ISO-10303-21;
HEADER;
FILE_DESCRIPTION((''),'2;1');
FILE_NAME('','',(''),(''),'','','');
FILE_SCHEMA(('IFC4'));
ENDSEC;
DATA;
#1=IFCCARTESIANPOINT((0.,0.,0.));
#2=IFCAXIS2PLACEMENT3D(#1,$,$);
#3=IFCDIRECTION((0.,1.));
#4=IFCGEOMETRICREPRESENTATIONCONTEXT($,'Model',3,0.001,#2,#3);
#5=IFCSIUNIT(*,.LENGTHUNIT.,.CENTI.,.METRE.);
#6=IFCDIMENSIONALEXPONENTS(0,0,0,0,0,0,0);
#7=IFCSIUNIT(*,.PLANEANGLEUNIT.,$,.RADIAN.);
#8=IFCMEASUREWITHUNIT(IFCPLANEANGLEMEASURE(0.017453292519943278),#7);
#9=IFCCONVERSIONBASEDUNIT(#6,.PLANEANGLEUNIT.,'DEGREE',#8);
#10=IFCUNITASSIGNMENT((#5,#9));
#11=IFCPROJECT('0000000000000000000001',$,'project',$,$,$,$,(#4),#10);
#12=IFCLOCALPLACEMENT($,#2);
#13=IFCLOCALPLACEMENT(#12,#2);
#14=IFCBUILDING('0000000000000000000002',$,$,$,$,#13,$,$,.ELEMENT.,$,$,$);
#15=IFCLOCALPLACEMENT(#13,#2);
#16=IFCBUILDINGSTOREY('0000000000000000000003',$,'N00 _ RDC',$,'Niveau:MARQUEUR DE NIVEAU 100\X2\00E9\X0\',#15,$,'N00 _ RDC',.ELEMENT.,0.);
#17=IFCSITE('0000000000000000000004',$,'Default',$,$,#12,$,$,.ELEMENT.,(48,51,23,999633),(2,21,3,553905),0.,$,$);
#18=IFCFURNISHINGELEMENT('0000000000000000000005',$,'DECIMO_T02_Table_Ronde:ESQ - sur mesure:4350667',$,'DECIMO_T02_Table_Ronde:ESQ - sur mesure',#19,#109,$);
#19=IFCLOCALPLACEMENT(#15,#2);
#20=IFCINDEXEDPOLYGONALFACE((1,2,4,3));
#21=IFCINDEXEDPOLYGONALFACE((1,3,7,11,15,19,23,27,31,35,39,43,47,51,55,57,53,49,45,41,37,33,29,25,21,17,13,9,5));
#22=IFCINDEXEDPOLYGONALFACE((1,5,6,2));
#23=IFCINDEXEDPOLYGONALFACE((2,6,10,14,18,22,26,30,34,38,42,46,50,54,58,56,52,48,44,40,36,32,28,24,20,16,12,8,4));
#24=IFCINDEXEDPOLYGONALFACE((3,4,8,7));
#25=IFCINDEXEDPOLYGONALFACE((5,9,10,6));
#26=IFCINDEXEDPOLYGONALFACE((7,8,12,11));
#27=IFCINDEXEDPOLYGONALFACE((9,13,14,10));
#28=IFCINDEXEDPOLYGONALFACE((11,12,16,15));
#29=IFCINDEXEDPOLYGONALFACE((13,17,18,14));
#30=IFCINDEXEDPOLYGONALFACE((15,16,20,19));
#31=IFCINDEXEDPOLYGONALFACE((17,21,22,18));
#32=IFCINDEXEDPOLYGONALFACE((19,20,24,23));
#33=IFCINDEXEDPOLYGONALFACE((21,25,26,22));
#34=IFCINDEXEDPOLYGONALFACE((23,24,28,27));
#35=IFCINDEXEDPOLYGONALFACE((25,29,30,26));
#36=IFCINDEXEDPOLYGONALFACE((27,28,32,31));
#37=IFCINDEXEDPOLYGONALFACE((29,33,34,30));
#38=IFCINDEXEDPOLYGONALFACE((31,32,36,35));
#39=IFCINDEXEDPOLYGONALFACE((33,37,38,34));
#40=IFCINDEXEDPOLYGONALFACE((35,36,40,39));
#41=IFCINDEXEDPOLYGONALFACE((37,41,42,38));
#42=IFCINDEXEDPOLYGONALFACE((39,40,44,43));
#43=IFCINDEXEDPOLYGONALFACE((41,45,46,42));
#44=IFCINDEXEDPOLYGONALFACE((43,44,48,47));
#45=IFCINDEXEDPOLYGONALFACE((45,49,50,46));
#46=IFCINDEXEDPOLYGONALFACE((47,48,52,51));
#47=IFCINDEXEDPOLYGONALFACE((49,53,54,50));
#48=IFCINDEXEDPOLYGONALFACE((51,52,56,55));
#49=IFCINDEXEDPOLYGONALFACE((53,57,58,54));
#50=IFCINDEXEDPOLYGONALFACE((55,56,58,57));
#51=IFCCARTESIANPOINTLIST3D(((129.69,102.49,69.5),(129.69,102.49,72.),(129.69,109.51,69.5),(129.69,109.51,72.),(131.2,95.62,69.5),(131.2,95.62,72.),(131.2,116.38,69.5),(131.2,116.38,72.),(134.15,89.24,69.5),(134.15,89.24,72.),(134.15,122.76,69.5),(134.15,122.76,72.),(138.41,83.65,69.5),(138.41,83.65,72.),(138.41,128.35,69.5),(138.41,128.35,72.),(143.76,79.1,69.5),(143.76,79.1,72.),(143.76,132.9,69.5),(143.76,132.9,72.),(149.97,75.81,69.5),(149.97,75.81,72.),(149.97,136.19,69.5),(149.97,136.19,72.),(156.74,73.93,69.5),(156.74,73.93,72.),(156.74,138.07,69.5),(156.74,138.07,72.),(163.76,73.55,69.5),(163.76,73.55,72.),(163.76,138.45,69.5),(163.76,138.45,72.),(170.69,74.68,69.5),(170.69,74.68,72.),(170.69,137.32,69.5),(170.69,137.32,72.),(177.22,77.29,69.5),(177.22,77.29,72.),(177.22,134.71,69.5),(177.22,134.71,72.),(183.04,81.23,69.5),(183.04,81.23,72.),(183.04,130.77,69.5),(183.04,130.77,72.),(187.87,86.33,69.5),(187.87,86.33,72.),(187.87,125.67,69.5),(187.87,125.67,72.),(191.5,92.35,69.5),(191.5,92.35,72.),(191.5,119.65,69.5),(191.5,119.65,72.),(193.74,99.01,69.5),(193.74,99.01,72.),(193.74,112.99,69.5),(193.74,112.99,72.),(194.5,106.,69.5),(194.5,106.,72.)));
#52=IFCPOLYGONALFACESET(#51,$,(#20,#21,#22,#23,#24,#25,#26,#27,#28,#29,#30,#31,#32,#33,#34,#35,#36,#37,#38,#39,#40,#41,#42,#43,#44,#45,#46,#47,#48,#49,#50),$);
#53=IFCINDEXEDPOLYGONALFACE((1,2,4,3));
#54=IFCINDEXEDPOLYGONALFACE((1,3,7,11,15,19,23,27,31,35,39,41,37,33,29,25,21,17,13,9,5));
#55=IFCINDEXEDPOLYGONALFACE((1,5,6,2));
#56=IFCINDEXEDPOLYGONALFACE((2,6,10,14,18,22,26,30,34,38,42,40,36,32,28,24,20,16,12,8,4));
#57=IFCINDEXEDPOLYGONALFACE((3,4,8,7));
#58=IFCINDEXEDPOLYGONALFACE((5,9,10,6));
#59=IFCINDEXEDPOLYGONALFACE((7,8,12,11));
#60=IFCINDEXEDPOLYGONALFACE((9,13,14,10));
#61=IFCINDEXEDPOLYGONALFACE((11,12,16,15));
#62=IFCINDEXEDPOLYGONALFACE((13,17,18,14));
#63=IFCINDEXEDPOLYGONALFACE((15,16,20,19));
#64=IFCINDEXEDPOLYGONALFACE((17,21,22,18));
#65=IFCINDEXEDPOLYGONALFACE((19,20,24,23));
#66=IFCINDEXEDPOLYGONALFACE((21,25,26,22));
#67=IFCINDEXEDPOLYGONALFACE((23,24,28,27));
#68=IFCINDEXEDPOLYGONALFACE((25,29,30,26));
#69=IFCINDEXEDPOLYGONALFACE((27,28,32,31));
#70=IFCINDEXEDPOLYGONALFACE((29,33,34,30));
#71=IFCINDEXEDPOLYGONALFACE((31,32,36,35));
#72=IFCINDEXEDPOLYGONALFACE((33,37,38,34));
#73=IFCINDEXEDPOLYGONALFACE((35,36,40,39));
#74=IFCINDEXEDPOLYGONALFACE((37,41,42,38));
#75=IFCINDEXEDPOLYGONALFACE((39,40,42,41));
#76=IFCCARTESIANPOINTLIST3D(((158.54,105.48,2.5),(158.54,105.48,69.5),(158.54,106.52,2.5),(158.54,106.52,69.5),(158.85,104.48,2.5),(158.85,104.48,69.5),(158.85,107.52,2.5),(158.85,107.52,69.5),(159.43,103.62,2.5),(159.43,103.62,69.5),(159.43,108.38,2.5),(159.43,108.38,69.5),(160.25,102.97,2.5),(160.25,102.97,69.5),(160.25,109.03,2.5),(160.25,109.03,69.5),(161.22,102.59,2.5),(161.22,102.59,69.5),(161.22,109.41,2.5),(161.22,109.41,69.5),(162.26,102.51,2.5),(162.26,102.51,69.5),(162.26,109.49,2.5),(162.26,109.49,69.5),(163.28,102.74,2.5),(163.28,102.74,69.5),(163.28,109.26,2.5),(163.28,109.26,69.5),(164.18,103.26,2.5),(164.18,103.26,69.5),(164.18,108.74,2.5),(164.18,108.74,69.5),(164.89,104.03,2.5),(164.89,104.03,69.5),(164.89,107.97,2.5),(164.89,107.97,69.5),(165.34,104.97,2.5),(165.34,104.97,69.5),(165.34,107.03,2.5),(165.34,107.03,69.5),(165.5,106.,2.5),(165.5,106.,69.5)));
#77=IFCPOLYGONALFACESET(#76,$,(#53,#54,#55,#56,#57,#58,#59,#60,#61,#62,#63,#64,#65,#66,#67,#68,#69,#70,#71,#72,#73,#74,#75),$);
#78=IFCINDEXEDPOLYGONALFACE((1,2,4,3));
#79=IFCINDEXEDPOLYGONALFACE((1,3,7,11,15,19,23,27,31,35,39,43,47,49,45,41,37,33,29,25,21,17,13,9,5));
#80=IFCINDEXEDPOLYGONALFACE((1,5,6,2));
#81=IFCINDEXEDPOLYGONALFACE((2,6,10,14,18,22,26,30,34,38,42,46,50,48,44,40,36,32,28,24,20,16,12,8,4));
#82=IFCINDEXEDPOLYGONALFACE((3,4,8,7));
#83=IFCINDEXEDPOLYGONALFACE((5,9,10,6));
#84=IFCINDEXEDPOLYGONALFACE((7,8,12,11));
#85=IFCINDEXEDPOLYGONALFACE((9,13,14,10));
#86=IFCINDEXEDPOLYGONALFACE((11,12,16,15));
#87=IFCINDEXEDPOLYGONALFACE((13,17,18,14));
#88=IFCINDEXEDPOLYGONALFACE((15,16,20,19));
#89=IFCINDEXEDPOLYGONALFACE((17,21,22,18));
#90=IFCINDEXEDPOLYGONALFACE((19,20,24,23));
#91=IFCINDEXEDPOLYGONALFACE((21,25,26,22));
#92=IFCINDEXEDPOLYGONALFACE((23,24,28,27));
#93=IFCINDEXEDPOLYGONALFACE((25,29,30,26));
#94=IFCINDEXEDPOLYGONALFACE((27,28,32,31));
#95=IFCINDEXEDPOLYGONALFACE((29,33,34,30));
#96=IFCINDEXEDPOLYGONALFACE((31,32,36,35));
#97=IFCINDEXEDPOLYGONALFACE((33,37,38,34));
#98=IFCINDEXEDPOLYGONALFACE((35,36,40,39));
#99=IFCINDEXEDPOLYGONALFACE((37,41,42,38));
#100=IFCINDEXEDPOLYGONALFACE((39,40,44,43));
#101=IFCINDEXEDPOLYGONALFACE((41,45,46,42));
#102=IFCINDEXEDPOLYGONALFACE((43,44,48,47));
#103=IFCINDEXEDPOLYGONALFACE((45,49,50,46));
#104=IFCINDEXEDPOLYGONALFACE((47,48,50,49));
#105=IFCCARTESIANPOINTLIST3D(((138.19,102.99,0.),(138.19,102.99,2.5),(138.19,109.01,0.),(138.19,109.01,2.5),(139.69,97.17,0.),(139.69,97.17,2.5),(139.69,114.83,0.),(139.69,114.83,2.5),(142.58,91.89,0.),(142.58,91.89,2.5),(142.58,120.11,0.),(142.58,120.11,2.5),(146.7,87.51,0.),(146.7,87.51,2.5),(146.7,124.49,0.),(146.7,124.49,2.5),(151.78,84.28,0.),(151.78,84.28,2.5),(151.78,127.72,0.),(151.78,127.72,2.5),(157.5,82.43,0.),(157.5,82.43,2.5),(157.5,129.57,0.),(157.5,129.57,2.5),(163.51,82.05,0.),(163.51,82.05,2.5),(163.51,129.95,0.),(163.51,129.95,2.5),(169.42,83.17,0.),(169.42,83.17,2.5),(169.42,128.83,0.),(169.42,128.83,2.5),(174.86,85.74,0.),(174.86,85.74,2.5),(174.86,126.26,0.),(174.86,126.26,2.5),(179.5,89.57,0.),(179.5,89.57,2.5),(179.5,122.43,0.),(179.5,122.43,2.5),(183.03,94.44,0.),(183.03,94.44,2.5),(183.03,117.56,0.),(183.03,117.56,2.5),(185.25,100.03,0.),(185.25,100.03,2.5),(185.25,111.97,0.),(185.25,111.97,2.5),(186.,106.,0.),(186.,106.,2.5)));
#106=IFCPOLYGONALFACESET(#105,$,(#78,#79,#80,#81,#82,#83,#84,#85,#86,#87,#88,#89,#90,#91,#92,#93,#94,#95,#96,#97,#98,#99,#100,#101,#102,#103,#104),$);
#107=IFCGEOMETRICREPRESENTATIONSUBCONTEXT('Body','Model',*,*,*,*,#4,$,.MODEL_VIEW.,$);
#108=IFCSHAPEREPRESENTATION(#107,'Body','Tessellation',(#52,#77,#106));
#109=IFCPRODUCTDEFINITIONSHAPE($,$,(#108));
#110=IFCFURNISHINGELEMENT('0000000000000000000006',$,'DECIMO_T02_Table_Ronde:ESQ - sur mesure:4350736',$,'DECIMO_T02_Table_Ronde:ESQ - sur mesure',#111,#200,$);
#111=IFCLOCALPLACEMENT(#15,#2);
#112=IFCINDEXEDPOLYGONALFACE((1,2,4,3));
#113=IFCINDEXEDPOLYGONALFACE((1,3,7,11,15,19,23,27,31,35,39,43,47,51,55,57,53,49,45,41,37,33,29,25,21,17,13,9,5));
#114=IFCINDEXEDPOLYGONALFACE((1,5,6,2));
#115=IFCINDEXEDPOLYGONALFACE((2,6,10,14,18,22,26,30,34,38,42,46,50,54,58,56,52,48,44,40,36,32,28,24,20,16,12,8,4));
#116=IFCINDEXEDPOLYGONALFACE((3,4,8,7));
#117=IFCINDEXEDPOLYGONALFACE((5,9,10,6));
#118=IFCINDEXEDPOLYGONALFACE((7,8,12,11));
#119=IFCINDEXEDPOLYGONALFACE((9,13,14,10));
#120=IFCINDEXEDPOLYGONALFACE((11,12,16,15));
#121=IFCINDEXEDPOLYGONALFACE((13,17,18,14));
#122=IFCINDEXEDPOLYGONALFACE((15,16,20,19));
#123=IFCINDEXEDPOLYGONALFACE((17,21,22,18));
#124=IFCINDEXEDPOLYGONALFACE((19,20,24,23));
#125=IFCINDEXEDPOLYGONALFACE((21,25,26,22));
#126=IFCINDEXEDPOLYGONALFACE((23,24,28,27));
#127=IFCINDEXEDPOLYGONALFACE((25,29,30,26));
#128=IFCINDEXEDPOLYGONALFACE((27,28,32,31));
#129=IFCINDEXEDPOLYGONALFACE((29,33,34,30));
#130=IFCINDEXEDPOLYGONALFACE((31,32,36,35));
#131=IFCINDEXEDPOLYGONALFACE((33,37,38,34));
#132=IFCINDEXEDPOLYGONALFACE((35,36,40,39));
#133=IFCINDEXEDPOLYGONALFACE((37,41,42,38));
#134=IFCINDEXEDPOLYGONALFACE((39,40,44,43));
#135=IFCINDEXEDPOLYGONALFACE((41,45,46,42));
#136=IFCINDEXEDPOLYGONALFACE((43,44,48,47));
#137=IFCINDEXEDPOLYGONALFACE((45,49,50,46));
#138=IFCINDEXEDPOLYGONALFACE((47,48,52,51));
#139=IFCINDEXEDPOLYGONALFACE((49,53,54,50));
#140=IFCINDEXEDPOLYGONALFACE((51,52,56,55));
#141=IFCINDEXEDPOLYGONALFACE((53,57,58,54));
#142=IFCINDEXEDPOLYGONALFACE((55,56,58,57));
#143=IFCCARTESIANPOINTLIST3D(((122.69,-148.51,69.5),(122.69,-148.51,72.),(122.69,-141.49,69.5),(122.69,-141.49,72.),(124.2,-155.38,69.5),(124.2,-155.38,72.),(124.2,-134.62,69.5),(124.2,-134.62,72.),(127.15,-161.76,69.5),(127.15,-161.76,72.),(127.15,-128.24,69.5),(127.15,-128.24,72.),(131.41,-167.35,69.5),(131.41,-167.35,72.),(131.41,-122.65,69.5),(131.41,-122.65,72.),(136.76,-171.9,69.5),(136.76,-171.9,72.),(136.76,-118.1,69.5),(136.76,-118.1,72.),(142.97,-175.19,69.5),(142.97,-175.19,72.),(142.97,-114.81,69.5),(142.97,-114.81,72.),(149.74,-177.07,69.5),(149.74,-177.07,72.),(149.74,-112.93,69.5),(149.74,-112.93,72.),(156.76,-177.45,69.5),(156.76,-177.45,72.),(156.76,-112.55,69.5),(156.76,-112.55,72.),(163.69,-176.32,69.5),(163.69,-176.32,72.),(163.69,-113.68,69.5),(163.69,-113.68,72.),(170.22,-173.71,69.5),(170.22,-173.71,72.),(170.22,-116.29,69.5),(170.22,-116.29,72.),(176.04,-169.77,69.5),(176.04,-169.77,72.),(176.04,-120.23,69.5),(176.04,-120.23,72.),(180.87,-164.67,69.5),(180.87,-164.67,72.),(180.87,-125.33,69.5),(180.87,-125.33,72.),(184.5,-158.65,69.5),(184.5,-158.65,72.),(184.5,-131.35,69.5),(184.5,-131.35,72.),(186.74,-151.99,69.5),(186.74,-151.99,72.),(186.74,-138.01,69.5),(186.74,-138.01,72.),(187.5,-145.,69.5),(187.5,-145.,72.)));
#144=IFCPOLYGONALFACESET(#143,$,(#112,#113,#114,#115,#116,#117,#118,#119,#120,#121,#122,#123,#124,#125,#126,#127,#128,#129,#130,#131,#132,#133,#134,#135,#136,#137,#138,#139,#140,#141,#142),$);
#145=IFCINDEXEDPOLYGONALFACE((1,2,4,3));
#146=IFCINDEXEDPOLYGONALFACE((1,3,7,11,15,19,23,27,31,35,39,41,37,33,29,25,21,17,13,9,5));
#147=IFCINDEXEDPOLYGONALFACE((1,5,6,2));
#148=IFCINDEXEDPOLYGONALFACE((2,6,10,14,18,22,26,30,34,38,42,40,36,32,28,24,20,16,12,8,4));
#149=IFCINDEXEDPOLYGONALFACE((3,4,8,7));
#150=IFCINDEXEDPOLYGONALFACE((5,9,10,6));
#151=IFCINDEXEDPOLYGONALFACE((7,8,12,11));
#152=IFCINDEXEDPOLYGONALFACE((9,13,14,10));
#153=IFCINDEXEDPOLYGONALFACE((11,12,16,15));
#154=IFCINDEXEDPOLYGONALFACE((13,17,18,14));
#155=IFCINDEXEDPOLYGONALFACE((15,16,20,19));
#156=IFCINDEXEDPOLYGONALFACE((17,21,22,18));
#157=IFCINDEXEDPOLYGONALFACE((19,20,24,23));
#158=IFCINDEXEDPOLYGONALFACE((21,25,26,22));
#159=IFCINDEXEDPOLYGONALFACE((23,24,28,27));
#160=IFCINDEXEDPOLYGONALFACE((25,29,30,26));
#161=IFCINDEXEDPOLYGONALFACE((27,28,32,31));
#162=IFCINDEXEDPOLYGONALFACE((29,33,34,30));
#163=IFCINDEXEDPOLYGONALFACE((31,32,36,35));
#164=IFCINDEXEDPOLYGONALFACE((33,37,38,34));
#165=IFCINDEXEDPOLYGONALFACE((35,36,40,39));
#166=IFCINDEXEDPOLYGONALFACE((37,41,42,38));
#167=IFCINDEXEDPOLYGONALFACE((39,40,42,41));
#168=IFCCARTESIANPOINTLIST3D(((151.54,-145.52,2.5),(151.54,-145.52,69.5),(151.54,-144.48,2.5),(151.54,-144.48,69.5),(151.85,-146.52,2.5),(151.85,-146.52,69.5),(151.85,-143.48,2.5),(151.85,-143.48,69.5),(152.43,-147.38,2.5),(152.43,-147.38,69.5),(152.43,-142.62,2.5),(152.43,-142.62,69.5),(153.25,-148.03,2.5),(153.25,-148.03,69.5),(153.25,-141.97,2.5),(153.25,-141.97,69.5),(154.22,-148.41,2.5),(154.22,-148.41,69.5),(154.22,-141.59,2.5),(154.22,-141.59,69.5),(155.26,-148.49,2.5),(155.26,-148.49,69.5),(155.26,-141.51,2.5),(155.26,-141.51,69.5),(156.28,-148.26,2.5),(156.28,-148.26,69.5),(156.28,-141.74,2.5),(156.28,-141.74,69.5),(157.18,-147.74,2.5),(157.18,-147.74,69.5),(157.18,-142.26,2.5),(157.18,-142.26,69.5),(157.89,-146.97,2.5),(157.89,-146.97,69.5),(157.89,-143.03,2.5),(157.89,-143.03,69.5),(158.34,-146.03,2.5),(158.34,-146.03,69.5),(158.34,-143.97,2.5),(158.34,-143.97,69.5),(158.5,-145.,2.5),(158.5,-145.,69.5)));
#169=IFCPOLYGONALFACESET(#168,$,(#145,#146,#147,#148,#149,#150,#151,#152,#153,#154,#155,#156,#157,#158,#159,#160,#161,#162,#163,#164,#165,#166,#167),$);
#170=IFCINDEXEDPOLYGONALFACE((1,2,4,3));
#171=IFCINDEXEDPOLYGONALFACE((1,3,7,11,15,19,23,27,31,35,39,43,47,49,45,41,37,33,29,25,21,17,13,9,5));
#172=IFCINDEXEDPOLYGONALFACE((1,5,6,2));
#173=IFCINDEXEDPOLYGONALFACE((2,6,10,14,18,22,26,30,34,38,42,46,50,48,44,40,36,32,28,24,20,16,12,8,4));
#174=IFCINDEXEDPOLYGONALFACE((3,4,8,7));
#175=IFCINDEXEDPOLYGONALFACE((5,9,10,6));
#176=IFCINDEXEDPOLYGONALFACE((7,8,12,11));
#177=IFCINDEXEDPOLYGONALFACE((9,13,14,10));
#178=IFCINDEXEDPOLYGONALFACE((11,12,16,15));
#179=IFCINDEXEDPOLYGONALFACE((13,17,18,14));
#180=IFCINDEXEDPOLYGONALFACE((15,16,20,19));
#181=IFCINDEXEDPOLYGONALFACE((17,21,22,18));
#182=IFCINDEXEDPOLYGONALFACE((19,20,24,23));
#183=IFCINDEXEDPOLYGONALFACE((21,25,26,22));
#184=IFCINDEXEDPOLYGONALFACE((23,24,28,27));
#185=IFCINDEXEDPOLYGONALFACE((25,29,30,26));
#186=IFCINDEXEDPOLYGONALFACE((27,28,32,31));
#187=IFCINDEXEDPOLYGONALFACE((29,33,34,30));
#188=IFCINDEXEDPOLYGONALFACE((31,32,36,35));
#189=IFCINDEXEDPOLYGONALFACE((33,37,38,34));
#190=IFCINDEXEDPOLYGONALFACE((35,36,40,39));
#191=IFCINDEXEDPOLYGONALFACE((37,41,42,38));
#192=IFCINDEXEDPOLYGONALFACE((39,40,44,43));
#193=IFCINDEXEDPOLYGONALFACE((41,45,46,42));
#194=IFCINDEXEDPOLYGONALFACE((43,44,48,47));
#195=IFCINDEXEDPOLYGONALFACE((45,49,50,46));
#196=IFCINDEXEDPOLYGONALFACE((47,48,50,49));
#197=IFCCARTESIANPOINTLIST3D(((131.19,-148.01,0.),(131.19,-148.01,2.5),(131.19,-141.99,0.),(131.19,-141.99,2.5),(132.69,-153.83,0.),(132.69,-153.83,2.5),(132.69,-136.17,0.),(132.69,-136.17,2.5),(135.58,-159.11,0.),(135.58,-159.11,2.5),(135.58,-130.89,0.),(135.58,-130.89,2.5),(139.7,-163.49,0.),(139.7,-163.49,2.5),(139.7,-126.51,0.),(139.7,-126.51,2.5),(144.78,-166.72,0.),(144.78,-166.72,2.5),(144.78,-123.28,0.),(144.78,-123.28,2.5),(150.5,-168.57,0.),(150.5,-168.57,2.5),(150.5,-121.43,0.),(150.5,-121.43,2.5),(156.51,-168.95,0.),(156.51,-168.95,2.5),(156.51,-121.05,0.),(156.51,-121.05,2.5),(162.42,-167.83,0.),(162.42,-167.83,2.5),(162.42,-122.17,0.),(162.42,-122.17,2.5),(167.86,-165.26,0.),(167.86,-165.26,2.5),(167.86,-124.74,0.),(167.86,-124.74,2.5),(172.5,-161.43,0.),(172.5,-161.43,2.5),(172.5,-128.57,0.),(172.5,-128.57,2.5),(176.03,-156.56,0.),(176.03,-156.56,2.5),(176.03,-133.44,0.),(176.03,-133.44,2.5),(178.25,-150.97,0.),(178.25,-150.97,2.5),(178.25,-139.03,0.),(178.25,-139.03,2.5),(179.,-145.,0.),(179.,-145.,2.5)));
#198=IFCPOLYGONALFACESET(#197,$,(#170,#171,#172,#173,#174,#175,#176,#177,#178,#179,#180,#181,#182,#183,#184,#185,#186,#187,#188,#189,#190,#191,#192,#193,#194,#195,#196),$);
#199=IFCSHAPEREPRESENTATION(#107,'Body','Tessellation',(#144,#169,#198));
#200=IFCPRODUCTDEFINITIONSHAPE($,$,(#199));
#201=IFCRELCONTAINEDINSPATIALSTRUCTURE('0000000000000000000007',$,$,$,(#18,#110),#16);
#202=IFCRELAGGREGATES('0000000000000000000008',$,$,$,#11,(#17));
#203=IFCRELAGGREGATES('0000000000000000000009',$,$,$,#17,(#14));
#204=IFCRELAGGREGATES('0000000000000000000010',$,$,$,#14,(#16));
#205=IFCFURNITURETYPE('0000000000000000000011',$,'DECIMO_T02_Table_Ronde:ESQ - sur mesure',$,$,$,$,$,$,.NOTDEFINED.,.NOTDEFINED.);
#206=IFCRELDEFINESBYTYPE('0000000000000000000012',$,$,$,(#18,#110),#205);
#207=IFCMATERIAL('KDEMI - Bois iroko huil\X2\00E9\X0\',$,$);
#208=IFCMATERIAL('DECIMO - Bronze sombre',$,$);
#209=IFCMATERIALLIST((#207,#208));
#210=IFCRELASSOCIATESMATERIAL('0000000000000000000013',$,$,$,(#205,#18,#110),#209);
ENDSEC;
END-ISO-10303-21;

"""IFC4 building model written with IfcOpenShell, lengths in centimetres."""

from ifc_helpers import new_model, entity, si_unit, converted_unit, direction, frame, frame_2d, origin, place, context, subcontext, project, spatial, circle, extrude, source, transform, mapped, material, material_list, type_object, type_shapes, element, save


model = new_model("IFC4")

# Units and contexts
model_context = context("Model", 3, precision=0.001, world=origin(), true_north=direction((0.0, 1.0)))
body_context = subcontext(model_context, "Body", "Model", "MODEL_VIEW")
ifc_project = project(units=[si_unit("LENGTHUNIT", "METRE", prefix="CENTI"), converted_unit("PLANEANGLEUNIT", "DEGREE", entity("IfcPlaneAngleMeasure", 0.017453292519943278), si_unit("PLANEANGLEUNIT", "RADIAN"), dimensions=[0, 0, 0, 0, 0, 0, 0])], contexts=[model_context])

# Site, building, storey
site_placement = place(None, origin())
site = spatial("IfcSite", under=ifc_project, at=site_placement, Name="Default", CompositionType="ELEMENT", RefLatitude=(48, 51, 23, 999633), RefLongitude=(2, 21, 3, 553905), RefElevation=0.0)
building_placement = place(site_placement, origin())
building = spatial("IfcBuilding", under=site, at=building_placement, CompositionType="ELEMENT")
storey_placement = place(building_placement, origin())
storey = spatial("IfcBuildingStorey", under=building, at=storey_placement, Name="N00 _ RDC", ObjectType="Niveau:MARQUEUR DE NIVEAU 100é", LongName="N00 _ RDC", CompositionType="ELEMENT", Elevation=0.0)

# Furnishing elements
ifc_material_1 = material(Name="KDEMI - Bois iroko huilé")
ifc_material_2 = material(Name="DECIMO - Bronze sombre")
ifc_material_list_1 = material_list([ifc_material_1, ifc_material_2])
furniture_type_1 = type_object("IfcFurnitureType", Name="DECIMO_T02_Table_Ronde:ESQ - sur mesure", AssemblyPlace="NOTDEFINED", material=ifc_material_list_1)
shared_shape_1 = source(origin(), body_context, "Body", "SweptSolid", [
    extrude(circle(Radius=32.5, at=frame_2d((0.0, 0.0), x_axis=(1.0, 0.0))), frame((0.0, 0.0, 69.5)), (0.0, 0.0, 1.0), 2.5),
    extrude(circle(Radius=3.5, at=frame_2d((0.0, 0.0), x_axis=(1.0, 0.0))), frame((0.0, 0.0, 2.5)), (0.0, 0.0, 1.0), 67.0),
    extrude(circle(Radius=24.0, at=frame_2d((0.0, 0.0), x_axis=(1.0, 0.0))), origin(), (0.0, 0.0, 1.0), 2.5),
])
type_shapes(furniture_type_1, [shared_shape_1])
for number, where, name in (
    (1, (162.0, 106.0, 0.0), "DECIMO_T02_Table_Ronde:ESQ - sur mesure:4350667"),
    (2, (155.0, -145.0, 0.0), "DECIMO_T02_Table_Ronde:ESQ - sur mesure:4350736"),
):
    element("IfcFurnishingElement", number, at=place(storey_placement, frame(where)), inside=storey, type_object=furniture_type_1, material=ifc_material_list_1, Name=name, ObjectType="DECIMO_T02_Table_Ronde:ESQ - sur mesure", context=body_context, shape_type="MappedRepresentation", body=[
        mapped(shared_shape_1, transform((0.0, 0.0, 0.0), scale=1.0)),
    ])

save(model, "model.ifc")
